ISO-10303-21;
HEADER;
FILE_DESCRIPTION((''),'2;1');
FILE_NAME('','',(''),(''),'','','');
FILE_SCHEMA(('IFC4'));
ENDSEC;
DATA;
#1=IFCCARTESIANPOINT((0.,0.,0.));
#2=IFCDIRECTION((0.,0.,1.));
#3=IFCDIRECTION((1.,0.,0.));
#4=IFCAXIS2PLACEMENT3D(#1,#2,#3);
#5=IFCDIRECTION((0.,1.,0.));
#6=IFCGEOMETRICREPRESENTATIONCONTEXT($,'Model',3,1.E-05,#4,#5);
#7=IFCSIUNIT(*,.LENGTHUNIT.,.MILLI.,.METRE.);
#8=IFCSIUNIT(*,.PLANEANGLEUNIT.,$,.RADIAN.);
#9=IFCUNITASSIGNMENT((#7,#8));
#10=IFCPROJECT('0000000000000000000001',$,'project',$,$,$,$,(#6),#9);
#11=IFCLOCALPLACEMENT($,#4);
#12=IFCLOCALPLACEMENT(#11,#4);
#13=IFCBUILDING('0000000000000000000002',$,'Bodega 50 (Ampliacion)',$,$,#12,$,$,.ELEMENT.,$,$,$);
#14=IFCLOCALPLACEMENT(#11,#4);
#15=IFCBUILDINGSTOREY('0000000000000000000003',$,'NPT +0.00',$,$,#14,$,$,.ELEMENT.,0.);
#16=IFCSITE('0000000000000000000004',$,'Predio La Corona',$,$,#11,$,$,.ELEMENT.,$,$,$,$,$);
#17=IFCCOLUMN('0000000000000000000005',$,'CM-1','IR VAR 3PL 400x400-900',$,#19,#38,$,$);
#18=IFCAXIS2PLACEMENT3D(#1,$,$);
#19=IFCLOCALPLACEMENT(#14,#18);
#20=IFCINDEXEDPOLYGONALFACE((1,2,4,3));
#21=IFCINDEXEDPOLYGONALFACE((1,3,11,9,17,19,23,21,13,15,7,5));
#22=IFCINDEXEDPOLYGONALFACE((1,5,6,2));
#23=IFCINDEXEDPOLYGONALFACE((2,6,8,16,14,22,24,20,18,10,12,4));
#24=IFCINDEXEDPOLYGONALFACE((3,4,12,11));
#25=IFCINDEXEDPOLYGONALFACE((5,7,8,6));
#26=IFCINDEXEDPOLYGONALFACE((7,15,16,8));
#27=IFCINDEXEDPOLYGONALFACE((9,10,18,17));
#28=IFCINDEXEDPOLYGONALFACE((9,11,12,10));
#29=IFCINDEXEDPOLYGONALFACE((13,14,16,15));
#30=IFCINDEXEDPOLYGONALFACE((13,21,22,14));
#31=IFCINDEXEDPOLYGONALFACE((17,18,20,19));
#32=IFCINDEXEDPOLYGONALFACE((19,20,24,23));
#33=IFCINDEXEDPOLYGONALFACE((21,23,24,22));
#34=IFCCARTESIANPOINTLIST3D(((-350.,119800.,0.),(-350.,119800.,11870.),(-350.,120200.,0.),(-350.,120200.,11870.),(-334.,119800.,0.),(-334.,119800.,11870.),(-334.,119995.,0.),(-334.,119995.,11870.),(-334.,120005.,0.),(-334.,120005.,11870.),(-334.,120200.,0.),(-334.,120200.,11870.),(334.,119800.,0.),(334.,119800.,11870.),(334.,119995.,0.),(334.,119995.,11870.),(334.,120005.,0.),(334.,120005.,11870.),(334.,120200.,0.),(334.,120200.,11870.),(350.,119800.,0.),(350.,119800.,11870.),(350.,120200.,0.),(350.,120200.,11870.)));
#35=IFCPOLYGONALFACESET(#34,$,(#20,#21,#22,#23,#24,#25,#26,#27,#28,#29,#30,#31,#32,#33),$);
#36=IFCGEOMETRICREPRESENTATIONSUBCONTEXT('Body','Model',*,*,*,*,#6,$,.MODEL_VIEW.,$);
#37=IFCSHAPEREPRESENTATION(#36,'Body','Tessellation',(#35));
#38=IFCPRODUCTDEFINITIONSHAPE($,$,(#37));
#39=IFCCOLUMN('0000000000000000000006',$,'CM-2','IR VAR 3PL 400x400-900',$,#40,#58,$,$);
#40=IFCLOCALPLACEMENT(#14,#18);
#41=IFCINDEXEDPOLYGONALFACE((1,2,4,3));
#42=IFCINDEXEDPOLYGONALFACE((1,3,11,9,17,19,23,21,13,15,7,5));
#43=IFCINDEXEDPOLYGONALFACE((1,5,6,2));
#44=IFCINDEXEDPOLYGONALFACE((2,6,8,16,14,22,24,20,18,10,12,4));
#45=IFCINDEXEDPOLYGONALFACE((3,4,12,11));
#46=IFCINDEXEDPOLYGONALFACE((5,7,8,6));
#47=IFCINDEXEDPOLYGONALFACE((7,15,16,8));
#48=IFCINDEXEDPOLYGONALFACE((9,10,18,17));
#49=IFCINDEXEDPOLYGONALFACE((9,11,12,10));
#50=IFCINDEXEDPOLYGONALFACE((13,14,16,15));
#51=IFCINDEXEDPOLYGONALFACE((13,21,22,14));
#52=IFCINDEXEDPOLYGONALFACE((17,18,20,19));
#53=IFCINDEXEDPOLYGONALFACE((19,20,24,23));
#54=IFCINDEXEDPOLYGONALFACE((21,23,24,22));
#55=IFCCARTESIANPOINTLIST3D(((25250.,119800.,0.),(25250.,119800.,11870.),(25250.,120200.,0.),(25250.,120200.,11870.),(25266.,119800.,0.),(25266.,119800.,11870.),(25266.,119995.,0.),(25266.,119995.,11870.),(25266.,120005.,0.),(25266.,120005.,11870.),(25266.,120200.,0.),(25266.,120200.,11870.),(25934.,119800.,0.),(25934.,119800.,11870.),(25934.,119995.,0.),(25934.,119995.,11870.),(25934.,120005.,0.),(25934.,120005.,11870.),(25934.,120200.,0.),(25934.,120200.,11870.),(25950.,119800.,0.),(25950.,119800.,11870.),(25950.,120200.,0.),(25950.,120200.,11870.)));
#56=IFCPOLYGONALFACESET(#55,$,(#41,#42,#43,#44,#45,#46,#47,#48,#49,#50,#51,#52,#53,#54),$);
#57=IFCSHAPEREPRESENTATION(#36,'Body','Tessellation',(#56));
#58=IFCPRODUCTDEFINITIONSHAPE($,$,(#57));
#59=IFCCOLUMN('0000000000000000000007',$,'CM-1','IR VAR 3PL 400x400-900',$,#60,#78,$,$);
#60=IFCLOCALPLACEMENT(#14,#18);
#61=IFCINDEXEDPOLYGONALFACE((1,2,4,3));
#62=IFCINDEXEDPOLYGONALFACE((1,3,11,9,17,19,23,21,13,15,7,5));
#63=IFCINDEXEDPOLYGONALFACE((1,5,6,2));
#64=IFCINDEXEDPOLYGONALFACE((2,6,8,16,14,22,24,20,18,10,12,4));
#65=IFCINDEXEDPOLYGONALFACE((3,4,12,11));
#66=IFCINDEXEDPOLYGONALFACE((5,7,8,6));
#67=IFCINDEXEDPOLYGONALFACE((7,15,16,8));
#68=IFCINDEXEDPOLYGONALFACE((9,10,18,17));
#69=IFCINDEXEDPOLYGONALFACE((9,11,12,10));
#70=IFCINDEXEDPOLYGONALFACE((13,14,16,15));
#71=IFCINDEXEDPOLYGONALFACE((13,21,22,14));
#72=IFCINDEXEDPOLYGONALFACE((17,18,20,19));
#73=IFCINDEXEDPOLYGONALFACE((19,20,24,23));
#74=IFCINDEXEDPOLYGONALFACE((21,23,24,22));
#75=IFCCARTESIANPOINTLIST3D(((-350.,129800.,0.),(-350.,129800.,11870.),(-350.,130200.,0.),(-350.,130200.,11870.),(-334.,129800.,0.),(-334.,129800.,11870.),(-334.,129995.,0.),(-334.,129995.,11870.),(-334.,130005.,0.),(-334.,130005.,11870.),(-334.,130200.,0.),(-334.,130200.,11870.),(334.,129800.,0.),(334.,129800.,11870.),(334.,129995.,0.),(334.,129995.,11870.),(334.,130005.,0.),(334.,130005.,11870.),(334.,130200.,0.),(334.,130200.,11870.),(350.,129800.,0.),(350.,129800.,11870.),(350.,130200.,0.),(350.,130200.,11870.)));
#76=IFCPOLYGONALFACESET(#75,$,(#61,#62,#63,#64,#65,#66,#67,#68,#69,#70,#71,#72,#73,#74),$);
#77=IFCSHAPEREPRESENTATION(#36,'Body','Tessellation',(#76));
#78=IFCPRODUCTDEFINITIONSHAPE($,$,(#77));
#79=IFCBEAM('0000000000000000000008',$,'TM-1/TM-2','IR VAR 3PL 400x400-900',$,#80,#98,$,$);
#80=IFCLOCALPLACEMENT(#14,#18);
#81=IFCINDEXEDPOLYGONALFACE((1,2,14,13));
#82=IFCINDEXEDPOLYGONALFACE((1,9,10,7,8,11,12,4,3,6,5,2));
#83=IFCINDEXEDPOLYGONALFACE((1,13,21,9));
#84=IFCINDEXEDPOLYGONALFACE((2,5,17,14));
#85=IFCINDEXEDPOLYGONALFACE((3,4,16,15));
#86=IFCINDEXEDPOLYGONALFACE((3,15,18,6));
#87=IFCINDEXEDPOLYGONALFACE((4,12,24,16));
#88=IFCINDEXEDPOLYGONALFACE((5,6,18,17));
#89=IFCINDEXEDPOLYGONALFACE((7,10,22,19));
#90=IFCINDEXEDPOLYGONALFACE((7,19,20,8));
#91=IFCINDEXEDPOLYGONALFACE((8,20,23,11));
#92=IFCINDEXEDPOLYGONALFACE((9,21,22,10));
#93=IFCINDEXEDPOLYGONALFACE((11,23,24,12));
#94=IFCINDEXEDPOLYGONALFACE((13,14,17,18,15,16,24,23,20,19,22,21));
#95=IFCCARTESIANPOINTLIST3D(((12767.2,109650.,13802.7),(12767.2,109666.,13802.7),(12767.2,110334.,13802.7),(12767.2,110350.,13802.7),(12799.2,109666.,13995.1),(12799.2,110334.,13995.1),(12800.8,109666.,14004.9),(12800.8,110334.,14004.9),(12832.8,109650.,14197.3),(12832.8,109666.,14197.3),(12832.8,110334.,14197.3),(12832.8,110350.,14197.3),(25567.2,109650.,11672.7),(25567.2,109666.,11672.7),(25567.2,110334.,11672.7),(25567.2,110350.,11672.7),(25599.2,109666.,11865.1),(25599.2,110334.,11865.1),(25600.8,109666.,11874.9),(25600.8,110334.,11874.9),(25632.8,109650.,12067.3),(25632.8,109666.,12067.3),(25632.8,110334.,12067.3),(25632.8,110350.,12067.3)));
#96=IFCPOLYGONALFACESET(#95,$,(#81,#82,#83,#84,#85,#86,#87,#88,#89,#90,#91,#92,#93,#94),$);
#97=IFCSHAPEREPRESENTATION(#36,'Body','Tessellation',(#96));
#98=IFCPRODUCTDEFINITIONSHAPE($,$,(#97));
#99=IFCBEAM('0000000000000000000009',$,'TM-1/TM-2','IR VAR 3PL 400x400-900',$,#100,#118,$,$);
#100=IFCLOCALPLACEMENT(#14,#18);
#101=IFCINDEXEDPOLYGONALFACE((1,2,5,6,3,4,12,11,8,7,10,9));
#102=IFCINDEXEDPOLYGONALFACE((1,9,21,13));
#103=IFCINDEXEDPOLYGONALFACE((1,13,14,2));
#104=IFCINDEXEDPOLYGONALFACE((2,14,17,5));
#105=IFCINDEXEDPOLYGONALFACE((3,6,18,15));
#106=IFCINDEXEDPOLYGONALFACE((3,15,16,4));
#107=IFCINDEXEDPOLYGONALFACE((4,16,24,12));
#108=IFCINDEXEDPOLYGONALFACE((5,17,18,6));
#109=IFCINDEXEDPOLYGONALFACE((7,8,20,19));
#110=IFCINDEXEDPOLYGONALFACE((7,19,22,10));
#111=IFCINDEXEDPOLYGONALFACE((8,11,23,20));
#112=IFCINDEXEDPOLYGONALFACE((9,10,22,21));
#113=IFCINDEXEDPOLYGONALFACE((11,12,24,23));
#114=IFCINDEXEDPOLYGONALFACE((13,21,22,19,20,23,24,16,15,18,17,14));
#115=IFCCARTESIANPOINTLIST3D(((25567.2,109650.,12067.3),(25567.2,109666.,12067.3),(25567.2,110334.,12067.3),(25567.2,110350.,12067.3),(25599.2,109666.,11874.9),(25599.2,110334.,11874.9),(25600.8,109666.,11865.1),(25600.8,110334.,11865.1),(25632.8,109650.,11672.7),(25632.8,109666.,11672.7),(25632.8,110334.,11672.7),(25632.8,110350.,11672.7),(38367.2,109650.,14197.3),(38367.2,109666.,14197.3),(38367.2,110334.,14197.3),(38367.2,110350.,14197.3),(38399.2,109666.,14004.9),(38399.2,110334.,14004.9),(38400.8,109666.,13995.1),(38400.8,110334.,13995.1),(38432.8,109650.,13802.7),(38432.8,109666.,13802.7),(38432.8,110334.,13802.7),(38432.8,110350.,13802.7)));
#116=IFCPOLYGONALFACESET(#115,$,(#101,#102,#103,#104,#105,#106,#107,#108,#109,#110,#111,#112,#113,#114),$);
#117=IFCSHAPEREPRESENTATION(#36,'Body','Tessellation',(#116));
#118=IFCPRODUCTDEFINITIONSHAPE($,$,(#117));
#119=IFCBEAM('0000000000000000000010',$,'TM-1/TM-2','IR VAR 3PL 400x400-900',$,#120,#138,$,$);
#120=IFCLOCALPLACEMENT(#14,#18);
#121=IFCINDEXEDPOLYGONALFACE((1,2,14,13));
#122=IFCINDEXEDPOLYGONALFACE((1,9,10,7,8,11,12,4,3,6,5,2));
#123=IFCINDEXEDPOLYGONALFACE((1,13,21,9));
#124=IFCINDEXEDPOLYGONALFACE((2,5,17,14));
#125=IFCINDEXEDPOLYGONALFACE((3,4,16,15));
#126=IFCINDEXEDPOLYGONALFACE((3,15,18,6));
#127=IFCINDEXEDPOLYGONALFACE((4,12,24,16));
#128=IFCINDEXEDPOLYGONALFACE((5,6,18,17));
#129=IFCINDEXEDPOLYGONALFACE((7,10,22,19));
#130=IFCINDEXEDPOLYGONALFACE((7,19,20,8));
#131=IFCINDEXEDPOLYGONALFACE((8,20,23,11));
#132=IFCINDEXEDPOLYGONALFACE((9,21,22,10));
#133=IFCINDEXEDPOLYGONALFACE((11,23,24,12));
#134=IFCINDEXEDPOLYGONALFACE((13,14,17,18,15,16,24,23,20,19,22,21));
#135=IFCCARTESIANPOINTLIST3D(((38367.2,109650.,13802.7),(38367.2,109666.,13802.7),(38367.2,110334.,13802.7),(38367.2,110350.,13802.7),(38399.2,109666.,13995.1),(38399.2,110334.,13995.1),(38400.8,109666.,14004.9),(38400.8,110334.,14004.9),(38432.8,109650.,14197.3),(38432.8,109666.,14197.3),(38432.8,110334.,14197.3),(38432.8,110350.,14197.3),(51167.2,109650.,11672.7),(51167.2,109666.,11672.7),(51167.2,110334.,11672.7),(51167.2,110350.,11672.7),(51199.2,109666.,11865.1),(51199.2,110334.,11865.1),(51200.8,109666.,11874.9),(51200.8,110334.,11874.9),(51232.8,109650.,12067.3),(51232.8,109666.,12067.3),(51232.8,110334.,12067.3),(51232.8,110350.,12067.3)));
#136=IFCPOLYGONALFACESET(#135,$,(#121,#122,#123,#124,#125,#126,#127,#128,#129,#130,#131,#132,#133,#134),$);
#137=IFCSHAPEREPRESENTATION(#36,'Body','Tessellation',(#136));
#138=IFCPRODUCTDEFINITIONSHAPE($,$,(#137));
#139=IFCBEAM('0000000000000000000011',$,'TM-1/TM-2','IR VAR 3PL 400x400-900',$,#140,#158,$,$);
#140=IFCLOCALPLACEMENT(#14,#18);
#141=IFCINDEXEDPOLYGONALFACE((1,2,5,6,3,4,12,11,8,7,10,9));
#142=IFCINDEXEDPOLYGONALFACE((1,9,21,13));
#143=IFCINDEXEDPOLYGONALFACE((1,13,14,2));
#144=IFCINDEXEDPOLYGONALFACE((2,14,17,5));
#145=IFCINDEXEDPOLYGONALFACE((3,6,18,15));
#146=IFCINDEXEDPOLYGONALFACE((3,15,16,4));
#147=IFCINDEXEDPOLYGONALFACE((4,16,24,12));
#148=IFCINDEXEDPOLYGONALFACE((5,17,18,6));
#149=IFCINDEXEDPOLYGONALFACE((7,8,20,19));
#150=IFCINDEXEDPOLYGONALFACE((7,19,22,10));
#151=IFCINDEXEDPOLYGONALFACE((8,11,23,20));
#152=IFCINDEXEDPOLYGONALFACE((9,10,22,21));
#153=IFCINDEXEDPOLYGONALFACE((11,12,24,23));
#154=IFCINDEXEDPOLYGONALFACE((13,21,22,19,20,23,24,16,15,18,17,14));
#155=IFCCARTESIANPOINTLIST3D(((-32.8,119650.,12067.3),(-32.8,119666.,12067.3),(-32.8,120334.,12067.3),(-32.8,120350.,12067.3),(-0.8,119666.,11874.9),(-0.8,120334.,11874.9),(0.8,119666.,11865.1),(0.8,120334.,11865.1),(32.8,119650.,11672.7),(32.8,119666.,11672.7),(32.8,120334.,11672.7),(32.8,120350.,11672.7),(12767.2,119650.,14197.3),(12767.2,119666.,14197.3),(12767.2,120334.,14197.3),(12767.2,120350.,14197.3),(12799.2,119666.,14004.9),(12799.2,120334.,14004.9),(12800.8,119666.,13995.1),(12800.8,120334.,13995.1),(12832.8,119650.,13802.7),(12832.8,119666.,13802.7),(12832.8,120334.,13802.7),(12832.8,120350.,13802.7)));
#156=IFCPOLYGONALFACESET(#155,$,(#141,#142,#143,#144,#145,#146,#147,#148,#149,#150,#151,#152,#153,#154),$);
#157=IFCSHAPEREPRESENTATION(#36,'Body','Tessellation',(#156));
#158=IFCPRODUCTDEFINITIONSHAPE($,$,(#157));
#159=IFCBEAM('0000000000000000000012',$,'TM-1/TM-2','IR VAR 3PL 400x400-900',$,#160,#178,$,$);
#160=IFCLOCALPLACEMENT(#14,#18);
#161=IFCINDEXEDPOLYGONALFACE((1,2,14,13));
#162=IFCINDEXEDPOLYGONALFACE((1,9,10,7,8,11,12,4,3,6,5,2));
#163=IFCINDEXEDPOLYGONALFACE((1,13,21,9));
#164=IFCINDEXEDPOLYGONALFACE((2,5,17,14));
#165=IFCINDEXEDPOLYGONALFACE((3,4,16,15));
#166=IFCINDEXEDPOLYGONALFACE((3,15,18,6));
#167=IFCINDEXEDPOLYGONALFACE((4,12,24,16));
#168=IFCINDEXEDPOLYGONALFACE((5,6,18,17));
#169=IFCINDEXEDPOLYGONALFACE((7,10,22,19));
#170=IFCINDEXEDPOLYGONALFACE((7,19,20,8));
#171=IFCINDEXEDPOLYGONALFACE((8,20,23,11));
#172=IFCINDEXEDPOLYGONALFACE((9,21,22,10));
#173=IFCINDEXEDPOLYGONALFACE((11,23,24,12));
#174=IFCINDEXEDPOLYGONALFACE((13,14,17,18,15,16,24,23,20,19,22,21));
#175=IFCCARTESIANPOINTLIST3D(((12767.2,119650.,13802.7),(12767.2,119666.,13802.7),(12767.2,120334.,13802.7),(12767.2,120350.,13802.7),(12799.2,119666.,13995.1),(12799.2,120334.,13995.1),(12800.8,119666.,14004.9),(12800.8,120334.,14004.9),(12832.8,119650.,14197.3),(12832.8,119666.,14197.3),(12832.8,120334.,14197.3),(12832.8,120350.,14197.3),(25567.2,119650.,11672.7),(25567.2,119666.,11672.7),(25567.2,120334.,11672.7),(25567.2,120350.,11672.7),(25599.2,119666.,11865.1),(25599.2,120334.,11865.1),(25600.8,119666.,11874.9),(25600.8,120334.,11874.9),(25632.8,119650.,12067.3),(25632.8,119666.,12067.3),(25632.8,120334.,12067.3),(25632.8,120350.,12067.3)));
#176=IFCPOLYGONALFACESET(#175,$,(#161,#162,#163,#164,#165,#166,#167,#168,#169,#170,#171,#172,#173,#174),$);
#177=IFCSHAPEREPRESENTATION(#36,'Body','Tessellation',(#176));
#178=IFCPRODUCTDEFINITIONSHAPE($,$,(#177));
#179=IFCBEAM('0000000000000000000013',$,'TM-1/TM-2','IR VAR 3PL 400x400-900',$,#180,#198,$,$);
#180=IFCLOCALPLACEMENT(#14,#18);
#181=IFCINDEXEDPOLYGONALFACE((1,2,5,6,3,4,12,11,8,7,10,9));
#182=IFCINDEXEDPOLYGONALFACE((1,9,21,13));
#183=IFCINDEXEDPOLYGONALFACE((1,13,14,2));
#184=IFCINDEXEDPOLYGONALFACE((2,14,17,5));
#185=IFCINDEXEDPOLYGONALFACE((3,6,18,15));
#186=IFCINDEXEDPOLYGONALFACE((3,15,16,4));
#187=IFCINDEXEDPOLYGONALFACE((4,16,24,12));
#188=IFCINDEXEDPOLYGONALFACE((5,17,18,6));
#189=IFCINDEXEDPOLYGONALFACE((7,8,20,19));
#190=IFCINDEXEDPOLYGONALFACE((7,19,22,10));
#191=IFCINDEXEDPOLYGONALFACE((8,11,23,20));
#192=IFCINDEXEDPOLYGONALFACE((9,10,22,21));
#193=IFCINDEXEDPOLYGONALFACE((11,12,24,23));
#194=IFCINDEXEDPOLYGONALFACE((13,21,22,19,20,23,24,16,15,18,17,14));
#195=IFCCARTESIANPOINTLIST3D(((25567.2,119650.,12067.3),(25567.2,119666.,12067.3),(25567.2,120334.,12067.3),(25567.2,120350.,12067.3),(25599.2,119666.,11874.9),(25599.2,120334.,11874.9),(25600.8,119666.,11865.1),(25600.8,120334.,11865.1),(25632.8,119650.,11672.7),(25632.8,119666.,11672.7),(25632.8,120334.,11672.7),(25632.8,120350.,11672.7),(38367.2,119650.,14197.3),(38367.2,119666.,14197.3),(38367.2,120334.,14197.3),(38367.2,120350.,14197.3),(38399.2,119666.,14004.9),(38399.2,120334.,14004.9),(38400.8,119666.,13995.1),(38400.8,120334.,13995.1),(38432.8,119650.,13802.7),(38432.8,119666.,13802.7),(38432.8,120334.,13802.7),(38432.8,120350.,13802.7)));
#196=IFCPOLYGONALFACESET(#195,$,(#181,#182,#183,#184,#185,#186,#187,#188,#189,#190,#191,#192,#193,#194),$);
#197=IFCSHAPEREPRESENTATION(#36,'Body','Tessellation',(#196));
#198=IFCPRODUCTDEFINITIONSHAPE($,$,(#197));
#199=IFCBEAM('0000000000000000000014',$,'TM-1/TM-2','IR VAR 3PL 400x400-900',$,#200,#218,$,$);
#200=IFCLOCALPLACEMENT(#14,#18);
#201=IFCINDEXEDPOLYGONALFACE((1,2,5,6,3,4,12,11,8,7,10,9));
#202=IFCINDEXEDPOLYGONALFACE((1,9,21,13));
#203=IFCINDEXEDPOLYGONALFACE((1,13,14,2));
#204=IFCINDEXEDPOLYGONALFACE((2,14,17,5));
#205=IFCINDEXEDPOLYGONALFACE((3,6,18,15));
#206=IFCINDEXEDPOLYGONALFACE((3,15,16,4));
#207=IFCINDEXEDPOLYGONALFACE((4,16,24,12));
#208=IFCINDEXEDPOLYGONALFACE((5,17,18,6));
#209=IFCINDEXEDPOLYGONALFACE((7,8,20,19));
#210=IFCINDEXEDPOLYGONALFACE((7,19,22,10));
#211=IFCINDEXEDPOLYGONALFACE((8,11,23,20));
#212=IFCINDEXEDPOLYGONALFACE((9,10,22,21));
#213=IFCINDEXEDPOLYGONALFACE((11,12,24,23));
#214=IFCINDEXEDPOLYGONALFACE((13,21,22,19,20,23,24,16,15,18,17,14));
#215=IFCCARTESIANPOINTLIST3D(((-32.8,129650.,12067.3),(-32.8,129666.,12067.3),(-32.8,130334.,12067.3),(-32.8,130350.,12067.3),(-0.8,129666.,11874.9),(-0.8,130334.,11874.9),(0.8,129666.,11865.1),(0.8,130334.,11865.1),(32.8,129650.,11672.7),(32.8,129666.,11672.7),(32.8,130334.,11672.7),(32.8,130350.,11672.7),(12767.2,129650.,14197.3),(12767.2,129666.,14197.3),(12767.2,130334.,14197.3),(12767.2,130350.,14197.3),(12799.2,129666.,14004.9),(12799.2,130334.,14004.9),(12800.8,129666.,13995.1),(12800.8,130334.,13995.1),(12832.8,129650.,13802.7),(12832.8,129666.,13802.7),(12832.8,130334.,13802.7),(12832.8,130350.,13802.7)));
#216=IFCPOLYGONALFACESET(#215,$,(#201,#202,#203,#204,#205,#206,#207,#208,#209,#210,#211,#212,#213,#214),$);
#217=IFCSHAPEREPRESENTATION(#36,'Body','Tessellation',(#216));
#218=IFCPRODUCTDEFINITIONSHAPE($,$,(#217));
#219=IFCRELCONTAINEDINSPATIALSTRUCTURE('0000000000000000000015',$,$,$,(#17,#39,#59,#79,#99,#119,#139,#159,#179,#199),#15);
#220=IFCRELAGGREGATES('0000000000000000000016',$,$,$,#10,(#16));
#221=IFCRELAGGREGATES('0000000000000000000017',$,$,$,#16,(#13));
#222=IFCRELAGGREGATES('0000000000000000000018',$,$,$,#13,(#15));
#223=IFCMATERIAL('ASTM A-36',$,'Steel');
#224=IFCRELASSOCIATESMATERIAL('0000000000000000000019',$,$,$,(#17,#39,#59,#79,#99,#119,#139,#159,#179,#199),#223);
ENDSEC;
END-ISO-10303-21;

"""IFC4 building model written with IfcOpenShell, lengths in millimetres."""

from ifc_helpers import new_model, si_unit, direction, frame, origin_with_axes, origin_2d, place, context, subcontext, project, spatial, i_section, extrude, material, element, save


model = new_model("IFC4")

# Units and contexts
model_context = context("Model", 3, precision=1e-05, world=origin_with_axes(), true_north=direction((0.0, 1.0, 0.0)))
body_context = subcontext(model_context, "Body", "Model", "MODEL_VIEW")
ifc_project = project(units=[si_unit("LENGTHUNIT", "METRE", prefix="MILLI"), si_unit("PLANEANGLEUNIT", "RADIAN")], contexts=[model_context])

# Site, building, storey
site_placement = place(None, origin_with_axes())
site = spatial("IfcSite", under=ifc_project, at=site_placement, Name="Predio La Corona", CompositionType="ELEMENT")
building_placement = place(site_placement, origin_with_axes())
building = spatial("IfcBuilding", under=site, at=building_placement, Name="Bodega 50 (Ampliacion)", CompositionType="ELEMENT")
storey_placement = place(site_placement, origin_with_axes())
storey = spatial("IfcBuildingStorey", under=building, at=storey_placement, Name="NPT +0.00", CompositionType="ELEMENT", Elevation=0.0)

# Columns
ifc_material = material(Name="ASTM A-36", Category="Steel")
for number, where, z_axis, x_axis, name in (
    (1, (0.0, 120000.0, 0.0), (0.0, 0.0, 1.0), (0.0, -1.0, 0.0), "CM-1"),
    (2, (25600.0, 120000.0, 0.0), (0.0, 0.0, 1.0), (0.0, -1.0, 0.0), "CM-2"),
    (3, (0.0, 130000.0, 0.0), (0.0, 0.0, 1.0), (0.0, -1.0, 0.0), "CM-1"),
):
    element("IfcColumn", number, at=place(storey_placement, frame(where, z_axis=z_axis, x_axis=x_axis)), inside=storey, material=ifc_material, Name=name, Description="IR VAR 3PL 400x400-900", context=body_context, shape_type="SweptSolid", body=[
        extrude(i_section(OverallWidth=400.0, OverallDepth=700.0, WebThickness=10.0, FlangeThickness=16.0, at=origin_2d()), origin_with_axes(), (0.0, 0.0, 1.0), 11870.0),
    ])

# Beams
for number, where, z_axis, x_axis, name in (
    (4, (12800.0, 110000.0, 14000.0), (0.986436, 0.0, -0.164149), (-0.164149, 0.0, -0.986436), "TM-1/TM-2"),
    (5, (25600.0, 110000.0, 11870.0), (0.986436, 0.0, 0.164149), (0.164149, 0.0, -0.986436), "TM-1/TM-2"),
    (6, (38400.0, 110000.0, 14000.0), (0.986436, 0.0, -0.164149), (-0.164149, 0.0, -0.986436), "TM-1/TM-2"),
    (7, (0.0, 120000.0, 11870.0), (0.986436, 0.0, 0.164149), (0.164149, 0.0, -0.986436), "TM-1/TM-2"),
    (8, (12800.0, 120000.0, 14000.0), (0.986436, 0.0, -0.164149), (-0.164149, 0.0, -0.986436), "TM-1/TM-2"),
    (9, (25600.0, 120000.0, 11870.0), (0.986436, 0.0, 0.164149), (0.164149, 0.0, -0.986436), "TM-1/TM-2"),
    (10, (0.0, 130000.0, 11870.0), (0.986436, 0.0, 0.164149), (0.164149, 0.0, -0.986436), "TM-1/TM-2"),
):
    element("IfcBeam", number, at=place(storey_placement, frame(where, z_axis=z_axis, x_axis=x_axis)), inside=storey, material=ifc_material, Name=name, Description="IR VAR 3PL 400x400-900", context=body_context, shape_type="SweptSolid", body=[
        extrude(i_section(OverallWidth=400.0, OverallDepth=700.0, WebThickness=10.0, FlangeThickness=16.0, at=origin_2d()), origin_with_axes(), (0.0, 0.0, 1.0), 12976.0),
    ])

save(model, "model.ifc")
